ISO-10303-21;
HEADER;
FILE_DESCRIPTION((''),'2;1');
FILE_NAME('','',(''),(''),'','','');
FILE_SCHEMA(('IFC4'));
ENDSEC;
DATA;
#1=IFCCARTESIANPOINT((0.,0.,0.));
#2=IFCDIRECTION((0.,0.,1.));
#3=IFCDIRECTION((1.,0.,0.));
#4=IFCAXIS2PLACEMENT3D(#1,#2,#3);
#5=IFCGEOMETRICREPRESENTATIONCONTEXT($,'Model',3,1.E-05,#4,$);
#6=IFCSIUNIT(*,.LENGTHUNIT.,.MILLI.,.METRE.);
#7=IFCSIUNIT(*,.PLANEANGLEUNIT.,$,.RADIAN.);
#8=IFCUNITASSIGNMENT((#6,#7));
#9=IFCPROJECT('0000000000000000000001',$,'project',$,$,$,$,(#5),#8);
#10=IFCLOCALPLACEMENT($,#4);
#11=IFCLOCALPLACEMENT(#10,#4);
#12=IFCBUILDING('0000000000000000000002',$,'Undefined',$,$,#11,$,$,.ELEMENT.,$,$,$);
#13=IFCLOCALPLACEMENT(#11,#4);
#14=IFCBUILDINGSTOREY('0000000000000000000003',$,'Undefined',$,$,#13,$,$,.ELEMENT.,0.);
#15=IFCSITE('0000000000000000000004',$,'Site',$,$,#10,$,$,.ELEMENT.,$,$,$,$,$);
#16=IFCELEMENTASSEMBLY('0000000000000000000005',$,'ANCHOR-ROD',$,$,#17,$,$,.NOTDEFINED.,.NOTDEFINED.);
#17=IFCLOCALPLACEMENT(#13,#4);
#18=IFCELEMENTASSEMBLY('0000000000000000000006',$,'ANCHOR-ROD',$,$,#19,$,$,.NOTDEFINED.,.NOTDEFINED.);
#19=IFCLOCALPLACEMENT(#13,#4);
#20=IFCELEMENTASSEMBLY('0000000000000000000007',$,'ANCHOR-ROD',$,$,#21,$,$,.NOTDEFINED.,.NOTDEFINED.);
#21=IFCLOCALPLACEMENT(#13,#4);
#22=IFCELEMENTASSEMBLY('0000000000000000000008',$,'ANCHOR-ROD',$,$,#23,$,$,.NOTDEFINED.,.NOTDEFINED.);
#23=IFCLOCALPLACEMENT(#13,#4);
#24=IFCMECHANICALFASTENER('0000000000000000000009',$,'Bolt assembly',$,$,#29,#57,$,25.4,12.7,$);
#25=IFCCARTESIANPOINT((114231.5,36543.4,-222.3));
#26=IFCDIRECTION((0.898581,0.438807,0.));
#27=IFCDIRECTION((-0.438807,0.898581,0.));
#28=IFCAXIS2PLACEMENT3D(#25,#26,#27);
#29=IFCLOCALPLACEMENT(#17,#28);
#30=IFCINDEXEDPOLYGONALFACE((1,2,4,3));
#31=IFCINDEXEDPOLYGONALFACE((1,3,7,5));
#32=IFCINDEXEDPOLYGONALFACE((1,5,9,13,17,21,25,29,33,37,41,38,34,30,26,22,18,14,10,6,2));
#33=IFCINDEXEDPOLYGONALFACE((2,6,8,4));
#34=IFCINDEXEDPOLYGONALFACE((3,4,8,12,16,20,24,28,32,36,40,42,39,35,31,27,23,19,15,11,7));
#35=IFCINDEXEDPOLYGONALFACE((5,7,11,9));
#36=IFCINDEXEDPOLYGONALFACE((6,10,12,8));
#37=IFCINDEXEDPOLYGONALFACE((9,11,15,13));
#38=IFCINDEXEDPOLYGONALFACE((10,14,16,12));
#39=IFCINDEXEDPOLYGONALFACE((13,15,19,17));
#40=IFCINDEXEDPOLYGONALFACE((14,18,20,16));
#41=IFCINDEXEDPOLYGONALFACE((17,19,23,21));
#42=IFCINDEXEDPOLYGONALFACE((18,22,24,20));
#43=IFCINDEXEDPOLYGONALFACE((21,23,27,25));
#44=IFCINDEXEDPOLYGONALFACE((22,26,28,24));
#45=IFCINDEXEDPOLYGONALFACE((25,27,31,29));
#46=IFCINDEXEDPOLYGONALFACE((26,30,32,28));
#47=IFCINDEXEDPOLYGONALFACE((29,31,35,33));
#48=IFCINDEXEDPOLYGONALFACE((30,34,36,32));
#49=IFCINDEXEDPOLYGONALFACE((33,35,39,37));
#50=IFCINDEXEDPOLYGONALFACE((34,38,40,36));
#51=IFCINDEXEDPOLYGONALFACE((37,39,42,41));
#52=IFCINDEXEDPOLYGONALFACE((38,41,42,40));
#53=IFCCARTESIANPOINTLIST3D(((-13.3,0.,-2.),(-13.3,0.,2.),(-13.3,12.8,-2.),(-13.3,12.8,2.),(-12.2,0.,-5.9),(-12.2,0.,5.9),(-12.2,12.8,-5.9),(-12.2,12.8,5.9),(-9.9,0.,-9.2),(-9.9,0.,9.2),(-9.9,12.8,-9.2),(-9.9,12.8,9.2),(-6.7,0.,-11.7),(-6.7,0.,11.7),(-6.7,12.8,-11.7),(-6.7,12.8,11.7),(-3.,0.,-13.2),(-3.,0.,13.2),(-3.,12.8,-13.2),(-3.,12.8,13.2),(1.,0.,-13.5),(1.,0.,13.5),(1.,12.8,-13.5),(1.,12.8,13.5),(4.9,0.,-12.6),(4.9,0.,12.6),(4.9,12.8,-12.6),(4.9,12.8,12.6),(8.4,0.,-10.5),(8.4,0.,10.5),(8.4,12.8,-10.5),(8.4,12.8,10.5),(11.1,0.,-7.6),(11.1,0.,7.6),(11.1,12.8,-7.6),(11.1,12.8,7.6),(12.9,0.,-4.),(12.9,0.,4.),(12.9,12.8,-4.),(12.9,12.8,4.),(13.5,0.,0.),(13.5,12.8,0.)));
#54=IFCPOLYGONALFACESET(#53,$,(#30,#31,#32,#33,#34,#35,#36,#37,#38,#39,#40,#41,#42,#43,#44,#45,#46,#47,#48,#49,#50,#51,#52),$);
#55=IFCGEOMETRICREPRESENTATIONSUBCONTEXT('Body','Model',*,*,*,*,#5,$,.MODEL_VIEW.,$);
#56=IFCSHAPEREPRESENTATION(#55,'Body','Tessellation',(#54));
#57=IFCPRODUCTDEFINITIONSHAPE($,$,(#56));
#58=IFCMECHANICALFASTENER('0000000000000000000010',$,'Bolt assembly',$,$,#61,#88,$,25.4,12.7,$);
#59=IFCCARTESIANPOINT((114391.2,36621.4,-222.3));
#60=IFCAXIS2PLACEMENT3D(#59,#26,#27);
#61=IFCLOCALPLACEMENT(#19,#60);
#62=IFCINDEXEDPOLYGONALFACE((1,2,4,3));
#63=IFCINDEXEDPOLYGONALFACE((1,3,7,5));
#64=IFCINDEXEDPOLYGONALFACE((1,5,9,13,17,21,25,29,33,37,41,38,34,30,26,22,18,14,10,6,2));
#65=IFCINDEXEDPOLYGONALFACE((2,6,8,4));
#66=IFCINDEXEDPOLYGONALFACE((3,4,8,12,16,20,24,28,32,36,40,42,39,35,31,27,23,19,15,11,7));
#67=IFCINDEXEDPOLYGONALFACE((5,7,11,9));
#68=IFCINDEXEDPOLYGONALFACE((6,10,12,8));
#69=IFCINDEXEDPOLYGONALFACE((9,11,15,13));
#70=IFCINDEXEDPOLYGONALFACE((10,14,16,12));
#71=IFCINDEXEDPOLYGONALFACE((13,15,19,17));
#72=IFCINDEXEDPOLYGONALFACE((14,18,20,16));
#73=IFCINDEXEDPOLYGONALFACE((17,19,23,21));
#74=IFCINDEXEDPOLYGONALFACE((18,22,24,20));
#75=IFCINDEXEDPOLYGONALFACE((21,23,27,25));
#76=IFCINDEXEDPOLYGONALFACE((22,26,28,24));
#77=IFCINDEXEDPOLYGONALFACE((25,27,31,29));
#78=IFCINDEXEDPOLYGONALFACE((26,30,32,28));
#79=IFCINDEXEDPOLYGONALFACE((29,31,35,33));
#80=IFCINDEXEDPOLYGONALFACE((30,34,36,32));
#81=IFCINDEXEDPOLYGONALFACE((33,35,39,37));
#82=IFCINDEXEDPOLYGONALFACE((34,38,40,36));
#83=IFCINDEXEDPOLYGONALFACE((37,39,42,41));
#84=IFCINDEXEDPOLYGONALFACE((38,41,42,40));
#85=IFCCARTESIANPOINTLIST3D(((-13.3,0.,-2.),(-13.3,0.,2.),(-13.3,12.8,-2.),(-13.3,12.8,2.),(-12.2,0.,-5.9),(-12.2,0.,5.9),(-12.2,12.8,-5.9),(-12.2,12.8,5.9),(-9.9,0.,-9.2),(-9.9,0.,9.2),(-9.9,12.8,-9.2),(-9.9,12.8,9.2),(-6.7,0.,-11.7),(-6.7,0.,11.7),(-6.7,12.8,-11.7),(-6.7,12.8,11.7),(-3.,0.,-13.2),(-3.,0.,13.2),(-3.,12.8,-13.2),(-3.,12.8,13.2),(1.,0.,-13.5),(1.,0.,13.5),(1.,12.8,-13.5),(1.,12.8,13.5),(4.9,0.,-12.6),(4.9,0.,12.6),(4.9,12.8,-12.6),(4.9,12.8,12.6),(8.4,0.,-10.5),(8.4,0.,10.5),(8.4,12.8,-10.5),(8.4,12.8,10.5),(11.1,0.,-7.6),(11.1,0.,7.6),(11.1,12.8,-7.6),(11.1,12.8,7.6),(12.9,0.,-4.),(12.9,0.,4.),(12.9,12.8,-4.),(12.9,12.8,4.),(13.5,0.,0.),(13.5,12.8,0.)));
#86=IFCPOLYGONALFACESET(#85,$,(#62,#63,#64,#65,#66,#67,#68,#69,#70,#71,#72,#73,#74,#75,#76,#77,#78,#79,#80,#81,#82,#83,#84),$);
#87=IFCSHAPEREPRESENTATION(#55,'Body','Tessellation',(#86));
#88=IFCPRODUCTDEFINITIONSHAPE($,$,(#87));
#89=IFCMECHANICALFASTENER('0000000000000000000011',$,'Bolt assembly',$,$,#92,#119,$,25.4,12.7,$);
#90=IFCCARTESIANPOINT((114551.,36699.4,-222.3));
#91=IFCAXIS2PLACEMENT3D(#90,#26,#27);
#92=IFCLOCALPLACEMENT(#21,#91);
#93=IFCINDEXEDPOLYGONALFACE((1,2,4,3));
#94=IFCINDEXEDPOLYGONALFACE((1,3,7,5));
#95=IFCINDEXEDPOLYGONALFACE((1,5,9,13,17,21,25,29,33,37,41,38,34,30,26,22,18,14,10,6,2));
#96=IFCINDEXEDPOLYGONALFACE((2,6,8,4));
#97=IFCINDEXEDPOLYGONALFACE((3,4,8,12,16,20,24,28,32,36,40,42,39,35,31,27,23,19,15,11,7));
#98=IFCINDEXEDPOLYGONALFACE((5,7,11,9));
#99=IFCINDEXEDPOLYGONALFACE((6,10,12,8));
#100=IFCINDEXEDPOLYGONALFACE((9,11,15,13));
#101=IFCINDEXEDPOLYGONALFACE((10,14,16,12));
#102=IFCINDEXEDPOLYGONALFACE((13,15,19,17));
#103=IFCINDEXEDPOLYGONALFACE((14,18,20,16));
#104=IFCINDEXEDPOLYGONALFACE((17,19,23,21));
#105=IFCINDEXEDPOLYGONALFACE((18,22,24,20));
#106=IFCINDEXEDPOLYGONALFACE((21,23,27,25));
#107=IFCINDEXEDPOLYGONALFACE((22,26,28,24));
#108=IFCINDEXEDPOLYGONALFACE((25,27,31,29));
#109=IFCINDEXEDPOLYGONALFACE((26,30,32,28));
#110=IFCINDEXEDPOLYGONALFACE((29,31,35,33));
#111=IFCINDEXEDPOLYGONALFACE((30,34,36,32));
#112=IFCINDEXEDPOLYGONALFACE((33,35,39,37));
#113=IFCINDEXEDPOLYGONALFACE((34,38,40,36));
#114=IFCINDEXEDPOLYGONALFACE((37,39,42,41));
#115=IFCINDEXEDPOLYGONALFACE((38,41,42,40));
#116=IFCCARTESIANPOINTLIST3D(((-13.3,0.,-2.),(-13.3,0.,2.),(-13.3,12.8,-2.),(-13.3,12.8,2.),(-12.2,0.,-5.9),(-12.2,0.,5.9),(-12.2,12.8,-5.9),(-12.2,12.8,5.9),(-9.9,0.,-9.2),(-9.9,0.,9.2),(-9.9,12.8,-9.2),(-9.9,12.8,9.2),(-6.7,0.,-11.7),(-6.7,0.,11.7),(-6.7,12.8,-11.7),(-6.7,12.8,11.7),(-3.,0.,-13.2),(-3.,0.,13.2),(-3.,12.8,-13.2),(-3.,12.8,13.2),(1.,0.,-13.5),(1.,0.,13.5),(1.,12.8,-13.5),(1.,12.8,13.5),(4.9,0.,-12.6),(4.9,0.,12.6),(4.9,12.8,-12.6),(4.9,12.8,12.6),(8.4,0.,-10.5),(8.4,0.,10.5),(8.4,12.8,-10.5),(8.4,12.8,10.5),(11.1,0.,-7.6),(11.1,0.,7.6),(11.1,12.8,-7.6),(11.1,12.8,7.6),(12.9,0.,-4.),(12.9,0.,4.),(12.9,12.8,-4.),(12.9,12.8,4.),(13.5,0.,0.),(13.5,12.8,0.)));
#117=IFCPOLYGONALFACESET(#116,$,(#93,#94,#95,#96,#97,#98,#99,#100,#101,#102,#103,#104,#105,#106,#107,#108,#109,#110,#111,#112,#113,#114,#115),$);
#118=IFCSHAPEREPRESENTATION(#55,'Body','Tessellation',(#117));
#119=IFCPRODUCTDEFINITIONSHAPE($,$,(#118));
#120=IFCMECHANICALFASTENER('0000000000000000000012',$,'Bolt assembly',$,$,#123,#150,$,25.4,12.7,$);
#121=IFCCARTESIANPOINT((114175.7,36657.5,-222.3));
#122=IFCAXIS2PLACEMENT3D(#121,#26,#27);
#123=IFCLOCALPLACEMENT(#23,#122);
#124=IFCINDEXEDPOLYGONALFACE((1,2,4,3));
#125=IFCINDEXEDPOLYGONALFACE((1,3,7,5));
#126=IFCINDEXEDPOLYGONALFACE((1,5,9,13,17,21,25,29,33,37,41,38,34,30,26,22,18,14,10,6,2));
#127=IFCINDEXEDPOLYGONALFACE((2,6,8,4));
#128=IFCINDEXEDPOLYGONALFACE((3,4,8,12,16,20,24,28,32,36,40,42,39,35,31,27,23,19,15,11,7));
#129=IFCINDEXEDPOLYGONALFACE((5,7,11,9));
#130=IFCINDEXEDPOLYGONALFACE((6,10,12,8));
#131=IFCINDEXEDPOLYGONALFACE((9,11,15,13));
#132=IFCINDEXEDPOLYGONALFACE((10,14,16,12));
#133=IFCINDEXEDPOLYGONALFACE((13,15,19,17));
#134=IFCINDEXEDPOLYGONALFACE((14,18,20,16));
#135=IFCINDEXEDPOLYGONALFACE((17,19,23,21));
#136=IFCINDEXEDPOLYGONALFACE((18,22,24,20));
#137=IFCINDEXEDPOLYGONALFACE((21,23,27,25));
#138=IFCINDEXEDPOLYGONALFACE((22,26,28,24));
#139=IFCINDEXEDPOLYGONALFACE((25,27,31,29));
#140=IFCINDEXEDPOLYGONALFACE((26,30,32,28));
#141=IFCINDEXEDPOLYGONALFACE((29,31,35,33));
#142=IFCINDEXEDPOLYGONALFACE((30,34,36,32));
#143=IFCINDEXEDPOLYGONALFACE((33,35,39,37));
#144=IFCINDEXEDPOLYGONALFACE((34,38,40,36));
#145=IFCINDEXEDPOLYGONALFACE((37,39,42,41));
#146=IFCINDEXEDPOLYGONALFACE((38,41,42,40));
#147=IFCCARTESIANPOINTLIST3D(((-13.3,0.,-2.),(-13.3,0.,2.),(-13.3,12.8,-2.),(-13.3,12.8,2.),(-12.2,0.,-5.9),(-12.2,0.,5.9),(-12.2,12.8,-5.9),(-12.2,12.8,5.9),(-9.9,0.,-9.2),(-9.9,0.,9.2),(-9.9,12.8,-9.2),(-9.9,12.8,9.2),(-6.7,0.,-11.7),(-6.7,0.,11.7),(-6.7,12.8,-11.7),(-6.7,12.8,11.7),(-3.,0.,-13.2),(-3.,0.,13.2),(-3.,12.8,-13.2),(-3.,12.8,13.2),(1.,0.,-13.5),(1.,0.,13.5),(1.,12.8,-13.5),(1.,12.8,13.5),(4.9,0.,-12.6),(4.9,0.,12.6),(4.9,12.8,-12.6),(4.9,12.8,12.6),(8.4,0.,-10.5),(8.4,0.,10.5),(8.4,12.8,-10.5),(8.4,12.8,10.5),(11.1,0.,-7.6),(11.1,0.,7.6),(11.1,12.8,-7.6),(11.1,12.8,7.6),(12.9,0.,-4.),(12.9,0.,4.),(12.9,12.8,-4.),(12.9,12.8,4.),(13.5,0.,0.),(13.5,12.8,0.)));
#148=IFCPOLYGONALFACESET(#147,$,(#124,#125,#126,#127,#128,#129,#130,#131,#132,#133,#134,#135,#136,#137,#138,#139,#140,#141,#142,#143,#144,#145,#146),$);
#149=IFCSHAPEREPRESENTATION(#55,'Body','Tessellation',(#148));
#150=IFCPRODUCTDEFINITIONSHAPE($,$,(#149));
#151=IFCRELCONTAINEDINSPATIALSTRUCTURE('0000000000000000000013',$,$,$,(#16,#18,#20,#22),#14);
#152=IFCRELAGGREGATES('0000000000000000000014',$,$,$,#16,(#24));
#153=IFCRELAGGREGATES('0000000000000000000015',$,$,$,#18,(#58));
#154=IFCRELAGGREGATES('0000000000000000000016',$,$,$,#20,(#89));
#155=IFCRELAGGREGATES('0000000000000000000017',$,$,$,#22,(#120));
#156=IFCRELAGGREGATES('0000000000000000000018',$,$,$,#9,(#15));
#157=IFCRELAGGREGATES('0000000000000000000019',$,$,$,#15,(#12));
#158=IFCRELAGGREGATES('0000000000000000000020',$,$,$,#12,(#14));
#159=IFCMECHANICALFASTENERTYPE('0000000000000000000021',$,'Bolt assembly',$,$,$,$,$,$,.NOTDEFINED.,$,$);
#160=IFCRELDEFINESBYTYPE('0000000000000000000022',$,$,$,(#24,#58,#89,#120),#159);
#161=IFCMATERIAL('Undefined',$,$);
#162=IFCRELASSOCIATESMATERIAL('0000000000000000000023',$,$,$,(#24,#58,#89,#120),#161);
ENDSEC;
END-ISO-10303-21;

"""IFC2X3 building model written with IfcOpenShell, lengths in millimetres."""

from ifc_helpers import new_model, si_unit, frame, origin_with_axes, origin_2d_with_axis, place, context, subcontext, project, spatial, circle, extrude, source, transform, mapped, material, type_object, element, aggregate, save


model = new_model("IFC2X3")

# Units and contexts
model_context = context("Model", 3, precision=1e-05, world=origin_with_axes())
body_context = subcontext(model_context, "Body", "Model", "MODEL_VIEW")
ifc_project = project(units=[si_unit("LENGTHUNIT", "METRE", prefix="MILLI"), si_unit("PLANEANGLEUNIT", "RADIAN")], contexts=[model_context])

# Site, building, storey
site_placement = place(None, origin_with_axes())
site = spatial("IfcSite", under=ifc_project, at=site_placement, Name="Site", CompositionType="ELEMENT")
building_placement = place(site_placement, origin_with_axes())
building = spatial("IfcBuilding", under=site, at=building_placement, Name="Undefined", CompositionType="ELEMENT")
storey_placement = place(building_placement, origin_with_axes())
storey = spatial("IfcBuildingStorey", under=building, at=storey_placement, Name="Undefined", CompositionType="ELEMENT", Elevation=0.0)

# Element assemblies
assembly_1_placement = place(storey_placement, origin_with_axes())
assembly_1 = element("IfcElementAssembly", 1, at=assembly_1_placement, inside=storey, Name="ANCHOR-ROD", AssemblyPlace="NOTDEFINED", PredefinedType="NOTDEFINED")
assembly_2_placement = place(storey_placement, origin_with_axes())
assembly_2 = element("IfcElementAssembly", 2, at=assembly_2_placement, inside=storey, Name="ANCHOR-ROD", AssemblyPlace="NOTDEFINED", PredefinedType="NOTDEFINED")
assembly_3_placement = place(storey_placement, origin_with_axes())
assembly_3 = element("IfcElementAssembly", 3, at=assembly_3_placement, inside=storey, Name="ANCHOR-ROD", AssemblyPlace="NOTDEFINED", PredefinedType="NOTDEFINED")
assembly_4_placement = place(storey_placement, origin_with_axes())
assembly_4 = element("IfcElementAssembly", 4, at=assembly_4_placement, inside=storey, Name="ANCHOR-ROD", AssemblyPlace="NOTDEFINED", PredefinedType="NOTDEFINED")

# Mechanical fasteners
ifc_material_1 = material(Name="Undefined")
mechanical_fastener_type = type_object("IfcMechanicalFastenerType", Name="Bolt assembly")
shared_shape_1 = source(origin_with_axes(), body_context, "Body", "SweptSolid", [
    extrude(circle(Radius=13.5, at=origin_2d_with_axis()), frame((0.0, 0.0, 0.0), z_axis=(0.0, 1.0, 0.0), x_axis=(1.0, 0.0, 0.0)), (0.0, 0.0, 1.0), 12.8),
])
mechanical_fastener_1_placement = place(assembly_1_placement, frame((114231.5, 36543.4, -222.3), z_axis=(0.898581, 0.438807, 0.0), x_axis=(-0.438807, 0.898581, 0.0)))
mechanical_fastener_1 = element("IfcMechanicalFastener", 5, at=mechanical_fastener_1_placement, type_object=mechanical_fastener_type, material=ifc_material_1, Name="Bolt assembly", NominalDiameter=25.4, NominalLength=12.7, context=body_context, shape_type="MappedRepresentation", body=[
    mapped(shared_shape_1, transform((0.0, 0.0, 0.0))),
])
aggregate(assembly_1, [mechanical_fastener_1])
mechanical_fastener_2_placement = place(assembly_2_placement, frame((114391.2, 36621.4, -222.3), z_axis=(0.898581, 0.438807, 0.0), x_axis=(-0.438807, 0.898581, 0.0)))
mechanical_fastener_2 = element("IfcMechanicalFastener", 6, at=mechanical_fastener_2_placement, type_object=mechanical_fastener_type, material=ifc_material_1, Name="Bolt assembly", NominalDiameter=25.4, NominalLength=12.7, context=body_context, shape_type="MappedRepresentation", body=[
    mapped(shared_shape_1, transform((0.0, 0.0, 0.0))),
])
aggregate(assembly_2, [mechanical_fastener_2])
mechanical_fastener_3_placement = place(assembly_3_placement, frame((114551.0, 36699.4, -222.3), z_axis=(0.898581, 0.438807, 0.0), x_axis=(-0.438807, 0.898581, 0.0)))
mechanical_fastener_3 = element("IfcMechanicalFastener", 7, at=mechanical_fastener_3_placement, type_object=mechanical_fastener_type, material=ifc_material_1, Name="Bolt assembly", NominalDiameter=25.4, NominalLength=12.7, context=body_context, shape_type="MappedRepresentation", body=[
    mapped(shared_shape_1, transform((0.0, 0.0, 0.0))),
])
aggregate(assembly_3, [mechanical_fastener_3])
mechanical_fastener_4_placement = place(assembly_4_placement, frame((114175.7, 36657.5, -222.3), z_axis=(0.898581, 0.438807, 0.0), x_axis=(-0.438807, 0.898581, 0.0)))
mechanical_fastener_4 = element("IfcMechanicalFastener", 8, at=mechanical_fastener_4_placement, type_object=mechanical_fastener_type, material=ifc_material_1, Name="Bolt assembly", NominalDiameter=25.4, NominalLength=12.7, context=body_context, shape_type="MappedRepresentation", body=[
    mapped(shared_shape_1, transform((0.0, 0.0, 0.0))),
])
aggregate(assembly_4, [mechanical_fastener_4])

save(model, "model.ifc")
